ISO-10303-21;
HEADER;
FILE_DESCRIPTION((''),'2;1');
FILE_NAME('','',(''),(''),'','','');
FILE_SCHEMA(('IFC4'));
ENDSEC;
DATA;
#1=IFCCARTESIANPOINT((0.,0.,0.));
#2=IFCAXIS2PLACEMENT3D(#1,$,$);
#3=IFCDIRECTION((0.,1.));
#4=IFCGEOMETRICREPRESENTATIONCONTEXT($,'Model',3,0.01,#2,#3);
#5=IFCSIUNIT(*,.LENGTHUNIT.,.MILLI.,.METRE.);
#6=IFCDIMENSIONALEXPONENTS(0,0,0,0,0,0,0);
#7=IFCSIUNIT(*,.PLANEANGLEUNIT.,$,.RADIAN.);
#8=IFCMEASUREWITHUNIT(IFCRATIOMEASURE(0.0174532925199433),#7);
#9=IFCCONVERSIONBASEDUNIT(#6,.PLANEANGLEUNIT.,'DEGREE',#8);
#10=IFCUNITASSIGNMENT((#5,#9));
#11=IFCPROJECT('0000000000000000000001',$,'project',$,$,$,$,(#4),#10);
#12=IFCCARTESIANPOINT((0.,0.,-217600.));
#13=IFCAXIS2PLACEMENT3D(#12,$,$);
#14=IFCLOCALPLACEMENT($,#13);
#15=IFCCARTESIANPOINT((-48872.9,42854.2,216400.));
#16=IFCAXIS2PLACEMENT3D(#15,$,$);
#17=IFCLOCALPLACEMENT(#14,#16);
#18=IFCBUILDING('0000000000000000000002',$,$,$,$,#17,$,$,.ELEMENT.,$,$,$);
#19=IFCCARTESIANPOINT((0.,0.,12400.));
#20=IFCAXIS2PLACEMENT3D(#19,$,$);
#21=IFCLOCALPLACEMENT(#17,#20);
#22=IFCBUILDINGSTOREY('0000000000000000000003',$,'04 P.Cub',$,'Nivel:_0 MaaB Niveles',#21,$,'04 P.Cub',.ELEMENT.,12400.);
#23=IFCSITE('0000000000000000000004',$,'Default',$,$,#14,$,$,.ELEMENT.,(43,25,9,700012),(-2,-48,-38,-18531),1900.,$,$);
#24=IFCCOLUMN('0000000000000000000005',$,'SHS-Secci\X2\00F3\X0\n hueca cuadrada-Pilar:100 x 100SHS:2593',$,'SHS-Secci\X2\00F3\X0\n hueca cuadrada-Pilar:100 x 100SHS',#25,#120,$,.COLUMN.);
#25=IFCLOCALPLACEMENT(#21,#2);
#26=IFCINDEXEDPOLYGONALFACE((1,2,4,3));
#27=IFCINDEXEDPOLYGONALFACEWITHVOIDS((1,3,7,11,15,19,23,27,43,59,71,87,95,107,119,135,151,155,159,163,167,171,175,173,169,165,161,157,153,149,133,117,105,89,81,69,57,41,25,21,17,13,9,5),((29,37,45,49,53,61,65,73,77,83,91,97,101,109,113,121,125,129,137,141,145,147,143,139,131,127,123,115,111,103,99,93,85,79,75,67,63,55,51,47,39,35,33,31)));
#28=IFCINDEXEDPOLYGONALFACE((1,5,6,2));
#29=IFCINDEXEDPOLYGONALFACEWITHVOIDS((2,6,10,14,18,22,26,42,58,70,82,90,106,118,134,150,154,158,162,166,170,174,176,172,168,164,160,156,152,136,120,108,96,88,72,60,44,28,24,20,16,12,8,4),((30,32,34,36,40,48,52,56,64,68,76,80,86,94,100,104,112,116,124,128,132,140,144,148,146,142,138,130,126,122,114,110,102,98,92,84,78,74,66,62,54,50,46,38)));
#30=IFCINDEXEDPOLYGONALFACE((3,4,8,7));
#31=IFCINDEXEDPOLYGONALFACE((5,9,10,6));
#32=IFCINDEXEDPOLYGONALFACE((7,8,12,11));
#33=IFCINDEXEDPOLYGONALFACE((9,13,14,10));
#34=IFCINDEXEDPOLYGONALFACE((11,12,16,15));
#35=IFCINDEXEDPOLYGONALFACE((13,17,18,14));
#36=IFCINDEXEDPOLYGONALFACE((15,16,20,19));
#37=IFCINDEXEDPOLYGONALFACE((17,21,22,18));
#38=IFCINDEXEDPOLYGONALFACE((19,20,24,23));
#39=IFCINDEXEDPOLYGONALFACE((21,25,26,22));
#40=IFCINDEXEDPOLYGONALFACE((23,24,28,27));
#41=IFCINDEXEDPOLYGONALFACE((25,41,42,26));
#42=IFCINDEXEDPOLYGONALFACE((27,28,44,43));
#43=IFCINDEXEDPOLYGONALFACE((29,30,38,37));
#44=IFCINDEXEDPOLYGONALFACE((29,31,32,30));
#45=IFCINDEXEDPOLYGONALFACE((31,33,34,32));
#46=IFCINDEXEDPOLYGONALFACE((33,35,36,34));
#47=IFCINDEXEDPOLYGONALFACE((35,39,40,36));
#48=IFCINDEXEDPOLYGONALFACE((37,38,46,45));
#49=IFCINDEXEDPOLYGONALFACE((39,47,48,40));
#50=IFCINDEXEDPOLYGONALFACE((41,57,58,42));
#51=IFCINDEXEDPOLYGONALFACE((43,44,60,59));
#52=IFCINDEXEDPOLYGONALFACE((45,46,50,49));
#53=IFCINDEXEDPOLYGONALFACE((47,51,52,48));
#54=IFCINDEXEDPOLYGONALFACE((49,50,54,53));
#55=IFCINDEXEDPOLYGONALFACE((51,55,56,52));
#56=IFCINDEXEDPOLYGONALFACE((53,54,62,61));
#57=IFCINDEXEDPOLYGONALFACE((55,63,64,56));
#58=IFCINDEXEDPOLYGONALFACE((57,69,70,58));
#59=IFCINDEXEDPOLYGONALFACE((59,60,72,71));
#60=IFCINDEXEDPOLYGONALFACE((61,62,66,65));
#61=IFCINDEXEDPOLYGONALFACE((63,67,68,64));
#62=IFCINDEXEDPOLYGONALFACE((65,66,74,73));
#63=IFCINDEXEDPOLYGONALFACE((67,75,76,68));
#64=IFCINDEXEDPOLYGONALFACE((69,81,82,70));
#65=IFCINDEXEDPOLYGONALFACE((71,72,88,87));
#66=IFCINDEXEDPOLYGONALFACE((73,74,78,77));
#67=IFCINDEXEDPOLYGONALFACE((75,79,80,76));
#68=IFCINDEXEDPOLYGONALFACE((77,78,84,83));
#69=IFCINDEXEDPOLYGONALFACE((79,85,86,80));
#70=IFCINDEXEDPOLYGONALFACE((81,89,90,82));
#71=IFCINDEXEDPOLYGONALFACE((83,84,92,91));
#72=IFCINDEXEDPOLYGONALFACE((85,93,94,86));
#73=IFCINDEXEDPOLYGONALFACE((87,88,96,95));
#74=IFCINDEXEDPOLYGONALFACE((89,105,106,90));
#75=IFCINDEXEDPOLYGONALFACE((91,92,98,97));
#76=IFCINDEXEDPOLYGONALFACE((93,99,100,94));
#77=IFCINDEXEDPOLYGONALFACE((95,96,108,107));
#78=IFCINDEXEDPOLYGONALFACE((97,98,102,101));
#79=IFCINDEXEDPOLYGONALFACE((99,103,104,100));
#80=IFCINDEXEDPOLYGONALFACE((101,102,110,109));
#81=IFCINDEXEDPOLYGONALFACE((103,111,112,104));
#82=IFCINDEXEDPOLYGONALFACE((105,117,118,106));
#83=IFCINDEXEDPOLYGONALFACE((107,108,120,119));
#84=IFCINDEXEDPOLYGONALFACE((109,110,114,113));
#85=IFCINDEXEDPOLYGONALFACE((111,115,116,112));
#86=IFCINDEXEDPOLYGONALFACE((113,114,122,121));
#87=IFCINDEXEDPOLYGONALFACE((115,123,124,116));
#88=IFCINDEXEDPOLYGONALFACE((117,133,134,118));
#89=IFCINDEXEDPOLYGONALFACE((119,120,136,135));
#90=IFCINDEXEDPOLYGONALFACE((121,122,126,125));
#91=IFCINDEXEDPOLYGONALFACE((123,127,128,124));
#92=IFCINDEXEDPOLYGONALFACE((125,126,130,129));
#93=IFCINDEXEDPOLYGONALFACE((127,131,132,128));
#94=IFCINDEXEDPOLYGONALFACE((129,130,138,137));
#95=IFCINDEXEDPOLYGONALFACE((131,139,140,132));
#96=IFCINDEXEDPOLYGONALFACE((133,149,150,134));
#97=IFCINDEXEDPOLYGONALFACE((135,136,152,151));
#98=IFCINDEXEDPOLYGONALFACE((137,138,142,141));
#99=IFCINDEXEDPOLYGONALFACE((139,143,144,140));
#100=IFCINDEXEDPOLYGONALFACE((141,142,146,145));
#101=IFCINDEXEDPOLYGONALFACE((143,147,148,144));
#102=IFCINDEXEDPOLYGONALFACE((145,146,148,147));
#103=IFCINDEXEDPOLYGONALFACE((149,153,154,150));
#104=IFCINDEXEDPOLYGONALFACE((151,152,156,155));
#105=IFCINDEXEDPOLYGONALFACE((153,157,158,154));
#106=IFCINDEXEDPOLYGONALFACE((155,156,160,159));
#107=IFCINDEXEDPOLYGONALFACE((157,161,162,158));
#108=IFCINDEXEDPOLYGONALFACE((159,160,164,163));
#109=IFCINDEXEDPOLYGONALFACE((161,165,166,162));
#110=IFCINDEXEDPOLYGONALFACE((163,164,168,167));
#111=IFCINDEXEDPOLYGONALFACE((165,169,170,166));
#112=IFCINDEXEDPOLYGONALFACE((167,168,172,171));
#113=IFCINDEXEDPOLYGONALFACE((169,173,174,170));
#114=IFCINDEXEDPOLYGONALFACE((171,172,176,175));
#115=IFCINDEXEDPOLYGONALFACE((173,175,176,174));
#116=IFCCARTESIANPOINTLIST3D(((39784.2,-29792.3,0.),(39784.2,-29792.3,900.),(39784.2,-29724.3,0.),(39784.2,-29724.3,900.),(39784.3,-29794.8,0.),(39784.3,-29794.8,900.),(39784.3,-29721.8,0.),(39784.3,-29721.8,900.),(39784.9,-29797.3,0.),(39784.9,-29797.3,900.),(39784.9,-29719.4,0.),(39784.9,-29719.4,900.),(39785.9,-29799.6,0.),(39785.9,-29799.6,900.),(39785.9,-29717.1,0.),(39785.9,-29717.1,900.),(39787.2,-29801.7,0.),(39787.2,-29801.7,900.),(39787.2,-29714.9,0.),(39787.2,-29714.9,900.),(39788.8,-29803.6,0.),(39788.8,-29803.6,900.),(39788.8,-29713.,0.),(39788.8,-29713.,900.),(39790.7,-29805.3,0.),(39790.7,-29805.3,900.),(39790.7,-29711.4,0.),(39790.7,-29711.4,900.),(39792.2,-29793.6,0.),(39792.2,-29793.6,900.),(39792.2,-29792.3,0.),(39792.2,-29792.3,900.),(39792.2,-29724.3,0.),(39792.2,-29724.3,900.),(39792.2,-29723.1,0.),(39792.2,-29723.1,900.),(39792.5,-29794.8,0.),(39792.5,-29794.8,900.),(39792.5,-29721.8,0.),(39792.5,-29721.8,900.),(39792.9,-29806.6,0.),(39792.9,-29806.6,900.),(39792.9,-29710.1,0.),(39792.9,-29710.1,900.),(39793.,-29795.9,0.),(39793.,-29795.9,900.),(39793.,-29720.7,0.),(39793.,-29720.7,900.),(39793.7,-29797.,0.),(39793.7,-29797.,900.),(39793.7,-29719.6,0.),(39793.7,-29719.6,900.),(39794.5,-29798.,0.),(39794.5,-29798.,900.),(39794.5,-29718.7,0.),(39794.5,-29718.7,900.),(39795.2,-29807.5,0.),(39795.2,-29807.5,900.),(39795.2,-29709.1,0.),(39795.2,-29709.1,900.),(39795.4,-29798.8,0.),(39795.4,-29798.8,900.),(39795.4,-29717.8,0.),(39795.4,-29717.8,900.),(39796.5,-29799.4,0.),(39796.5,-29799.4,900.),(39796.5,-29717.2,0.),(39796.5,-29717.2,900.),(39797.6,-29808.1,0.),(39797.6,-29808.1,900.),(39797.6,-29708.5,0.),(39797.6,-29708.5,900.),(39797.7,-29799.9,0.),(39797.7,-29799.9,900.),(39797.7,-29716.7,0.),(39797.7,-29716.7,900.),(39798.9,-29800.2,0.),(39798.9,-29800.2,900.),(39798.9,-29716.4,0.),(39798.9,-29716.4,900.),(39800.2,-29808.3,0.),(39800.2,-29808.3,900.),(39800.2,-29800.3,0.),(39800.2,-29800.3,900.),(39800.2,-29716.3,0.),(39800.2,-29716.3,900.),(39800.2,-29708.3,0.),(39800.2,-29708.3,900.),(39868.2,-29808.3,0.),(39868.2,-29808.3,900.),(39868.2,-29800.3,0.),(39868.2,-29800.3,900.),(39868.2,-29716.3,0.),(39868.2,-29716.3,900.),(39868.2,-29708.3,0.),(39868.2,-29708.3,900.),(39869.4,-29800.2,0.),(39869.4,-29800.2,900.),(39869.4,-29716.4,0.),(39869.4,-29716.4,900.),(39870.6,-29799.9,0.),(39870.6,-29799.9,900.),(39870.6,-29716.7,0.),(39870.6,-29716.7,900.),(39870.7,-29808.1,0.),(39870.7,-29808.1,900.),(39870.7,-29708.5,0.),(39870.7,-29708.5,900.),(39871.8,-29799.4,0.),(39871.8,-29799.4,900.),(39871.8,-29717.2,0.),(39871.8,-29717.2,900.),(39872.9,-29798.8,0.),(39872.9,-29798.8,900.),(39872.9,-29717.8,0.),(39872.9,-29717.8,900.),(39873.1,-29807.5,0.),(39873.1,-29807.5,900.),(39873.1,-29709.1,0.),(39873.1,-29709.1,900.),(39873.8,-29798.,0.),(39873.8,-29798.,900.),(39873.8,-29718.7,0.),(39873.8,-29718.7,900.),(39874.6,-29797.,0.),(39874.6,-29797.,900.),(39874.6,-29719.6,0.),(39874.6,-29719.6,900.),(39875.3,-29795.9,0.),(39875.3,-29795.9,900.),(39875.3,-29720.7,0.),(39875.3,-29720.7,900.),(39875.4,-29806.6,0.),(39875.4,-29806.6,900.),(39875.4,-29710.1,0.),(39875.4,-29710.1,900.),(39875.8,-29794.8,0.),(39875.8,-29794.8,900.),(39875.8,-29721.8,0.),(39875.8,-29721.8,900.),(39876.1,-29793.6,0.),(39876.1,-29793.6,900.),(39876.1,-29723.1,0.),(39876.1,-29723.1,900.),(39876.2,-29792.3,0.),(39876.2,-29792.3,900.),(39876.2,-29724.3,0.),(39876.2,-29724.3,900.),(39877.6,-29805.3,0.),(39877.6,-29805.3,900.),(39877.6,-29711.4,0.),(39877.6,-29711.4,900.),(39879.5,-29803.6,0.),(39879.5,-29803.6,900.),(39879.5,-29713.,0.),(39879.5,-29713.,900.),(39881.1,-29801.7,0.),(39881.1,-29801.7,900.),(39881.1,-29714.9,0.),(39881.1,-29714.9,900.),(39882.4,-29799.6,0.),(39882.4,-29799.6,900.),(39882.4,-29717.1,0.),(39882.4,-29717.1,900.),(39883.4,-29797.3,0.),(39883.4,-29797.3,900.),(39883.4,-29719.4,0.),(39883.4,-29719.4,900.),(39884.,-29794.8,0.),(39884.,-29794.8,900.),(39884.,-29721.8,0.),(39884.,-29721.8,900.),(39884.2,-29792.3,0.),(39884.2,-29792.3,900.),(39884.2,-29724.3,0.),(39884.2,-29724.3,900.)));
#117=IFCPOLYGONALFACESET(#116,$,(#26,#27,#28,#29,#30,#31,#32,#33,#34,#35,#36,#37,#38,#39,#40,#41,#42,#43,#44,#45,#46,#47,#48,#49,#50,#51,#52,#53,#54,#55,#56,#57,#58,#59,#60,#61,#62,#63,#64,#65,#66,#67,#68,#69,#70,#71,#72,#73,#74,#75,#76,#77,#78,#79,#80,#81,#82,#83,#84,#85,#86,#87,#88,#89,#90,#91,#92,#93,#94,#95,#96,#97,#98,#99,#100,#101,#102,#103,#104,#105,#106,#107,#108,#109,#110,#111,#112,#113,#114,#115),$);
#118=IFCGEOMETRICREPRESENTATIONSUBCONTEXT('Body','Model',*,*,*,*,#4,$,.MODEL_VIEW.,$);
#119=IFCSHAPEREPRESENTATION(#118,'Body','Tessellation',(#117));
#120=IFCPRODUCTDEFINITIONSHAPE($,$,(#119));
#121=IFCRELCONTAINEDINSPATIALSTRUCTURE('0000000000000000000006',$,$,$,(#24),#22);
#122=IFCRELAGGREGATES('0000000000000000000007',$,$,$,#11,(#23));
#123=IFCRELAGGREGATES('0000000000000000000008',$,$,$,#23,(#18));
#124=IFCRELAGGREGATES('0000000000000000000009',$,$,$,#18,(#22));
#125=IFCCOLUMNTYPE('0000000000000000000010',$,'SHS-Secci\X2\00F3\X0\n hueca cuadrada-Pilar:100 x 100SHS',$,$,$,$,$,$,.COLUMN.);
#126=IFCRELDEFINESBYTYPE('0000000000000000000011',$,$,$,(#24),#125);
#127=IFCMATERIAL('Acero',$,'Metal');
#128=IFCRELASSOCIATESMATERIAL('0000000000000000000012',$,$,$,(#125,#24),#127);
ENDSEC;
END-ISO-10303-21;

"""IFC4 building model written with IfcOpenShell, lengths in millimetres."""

from ifc_helpers import new_model, entity, si_unit, converted_unit, direction, frame, origin, place, context, subcontext, project, spatial, indexed_curve, outline, extrude, source, transform, mapped, material, type_object, type_shapes, element, save


model = new_model("IFC4")

# Units and contexts
model_context = context("Model", 3, precision=0.01, world=origin(), true_north=direction((0.0, 1.0)))
body_context = subcontext(model_context, "Body", "Model", "MODEL_VIEW")
ifc_project = project(units=[si_unit("LENGTHUNIT", "METRE", prefix="MILLI"), converted_unit("PLANEANGLEUNIT", "DEGREE", entity("IfcRatioMeasure", 0.0174532925199433), si_unit("PLANEANGLEUNIT", "RADIAN"), dimensions=[0, 0, 0, 0, 0, 0, 0])], contexts=[model_context])

# Site, building, storey
site_placement = place(None, frame((0.0, 0.0, -217600.0)))
site = spatial("IfcSite", under=ifc_project, at=site_placement, Name="Default", CompositionType="ELEMENT", RefLatitude=(43, 25, 9, 700012), RefLongitude=(-2, -48, -38, -18531), RefElevation=1900.0)
building_placement = place(site_placement, frame((-48872.9, 42854.2, 216400.0)))
building = spatial("IfcBuilding", under=site, at=building_placement, CompositionType="ELEMENT")
storey_placement = place(building_placement, frame((0.0, 0.0, 12400.0)))
storey = spatial("IfcBuildingStorey", under=building, at=storey_placement, Name="04 P.Cub", ObjectType="Nivel:_0 MaaB Niveles", LongName="04 P.Cub", CompositionType="ELEMENT", Elevation=12400.0)

# Column
ifc_material_1 = material(Name="Acero", Category="Metal")
column_type_1 = type_object("IfcColumnType", Name="SHS-Sección hueca cuadrada-Pilar:100 x 100SHS", PredefinedType="COLUMN", material=ifc_material_1)
shared_shape_1 = source(origin(), body_context, "Body", "SweptSolid", [
    extrude(outline(indexed_curve([(-34.0, -50.0), (34.0, -50.0), (36.5, -49.8), (38.9, -49.2), (41.3, -48.3), (43.4, -46.9), (45.3, -45.3), (46.9, -43.4), (48.3, -41.3), (49.2, -38.9), (49.8, -36.5), (50.0, -34.0), (50.0, 34.0), (49.8, 36.5), (49.2, 38.9), (48.3, 41.3), (46.9, 43.4), (45.3, 45.3), (43.4, 46.9), (41.3, 48.3), (38.9, 49.2), (36.5, 49.8), (34.0, 50.0), (-34.0, 50.0), (-36.5, 49.8), (-38.9, 49.2), (-41.3, 48.3), (-43.4, 46.9), (-45.3, 45.3), (-46.9, 43.4), (-48.3, 41.3), (-49.2, 38.9), (-49.8, 36.5), (-50.0, 34.0), (-50.0, -34.0), (-49.8, -36.5), (-49.2, -38.9), (-48.3, -41.3), (-46.9, -43.4), (-45.3, -45.3), (-43.4, -46.9), (-41.3, -48.3), (-38.9, -49.2), (-36.5, -49.8), (-34.0, -50.0)], self_intersect=False), holes=[indexed_curve([(-34.0, -42.0), (-35.3, -41.9), (-36.5, -41.6), (-37.6, -41.1), (-38.7, -40.5), (-39.7, -39.7), (-40.5, -38.7), (-41.1, -37.6), (-41.6, -36.5), (-41.9, -35.3), (-42.0, -34.0), (-42.0, 34.0), (-41.9, 35.3), (-41.6, 36.5), (-41.1, 37.6), (-40.5, 38.7), (-39.7, 39.7), (-38.7, 40.5), (-37.6, 41.1), (-36.5, 41.6), (-35.3, 41.9), (-34.0, 42.0), (34.0, 42.0), (35.3, 41.9), (36.5, 41.6), (37.6, 41.1), (38.7, 40.5), (39.7, 39.7), (40.5, 38.7), (41.1, 37.6), (41.6, 36.5), (41.9, 35.3), (42.0, 34.0), (42.0, -34.0), (41.9, -35.3), (41.6, -36.5), (41.1, -37.6), (40.5, -38.7), (39.7, -39.7), (38.7, -40.5), (37.6, -41.1), (36.5, -41.6), (35.3, -41.9), (34.0, -42.0), (-34.0, -42.0)], self_intersect=False)]), frame((0.0, 0.0, 12400.0), z_axis=(0.0, 0.0, 1.0), x_axis=(-1.0, 0.0, 0.0)), (0.0, 0.0, 1.0), 900.0),
])
type_shapes(column_type_1, [shared_shape_1])
column_1_placement = place(storey_placement, frame((39834.2, -29758.3, -12400.0), z_axis=(0.0, 0.0, 1.0), x_axis=(0.0, -1.0, 0.0)))
element("IfcColumn", 1, at=column_1_placement, inside=storey, type_object=column_type_1, material=ifc_material_1, Name="SHS-Sección hueca cuadrada-Pilar:100 x 100SHS:2593", ObjectType="SHS-Sección hueca cuadrada-Pilar:100 x 100SHS", PredefinedType="COLUMN", context=body_context, shape_type="MappedRepresentation", body=[
    mapped(shared_shape_1, transform((0.0, 0.0, 0.0), scale=1.0)),
])

save(model, "model.ifc")
